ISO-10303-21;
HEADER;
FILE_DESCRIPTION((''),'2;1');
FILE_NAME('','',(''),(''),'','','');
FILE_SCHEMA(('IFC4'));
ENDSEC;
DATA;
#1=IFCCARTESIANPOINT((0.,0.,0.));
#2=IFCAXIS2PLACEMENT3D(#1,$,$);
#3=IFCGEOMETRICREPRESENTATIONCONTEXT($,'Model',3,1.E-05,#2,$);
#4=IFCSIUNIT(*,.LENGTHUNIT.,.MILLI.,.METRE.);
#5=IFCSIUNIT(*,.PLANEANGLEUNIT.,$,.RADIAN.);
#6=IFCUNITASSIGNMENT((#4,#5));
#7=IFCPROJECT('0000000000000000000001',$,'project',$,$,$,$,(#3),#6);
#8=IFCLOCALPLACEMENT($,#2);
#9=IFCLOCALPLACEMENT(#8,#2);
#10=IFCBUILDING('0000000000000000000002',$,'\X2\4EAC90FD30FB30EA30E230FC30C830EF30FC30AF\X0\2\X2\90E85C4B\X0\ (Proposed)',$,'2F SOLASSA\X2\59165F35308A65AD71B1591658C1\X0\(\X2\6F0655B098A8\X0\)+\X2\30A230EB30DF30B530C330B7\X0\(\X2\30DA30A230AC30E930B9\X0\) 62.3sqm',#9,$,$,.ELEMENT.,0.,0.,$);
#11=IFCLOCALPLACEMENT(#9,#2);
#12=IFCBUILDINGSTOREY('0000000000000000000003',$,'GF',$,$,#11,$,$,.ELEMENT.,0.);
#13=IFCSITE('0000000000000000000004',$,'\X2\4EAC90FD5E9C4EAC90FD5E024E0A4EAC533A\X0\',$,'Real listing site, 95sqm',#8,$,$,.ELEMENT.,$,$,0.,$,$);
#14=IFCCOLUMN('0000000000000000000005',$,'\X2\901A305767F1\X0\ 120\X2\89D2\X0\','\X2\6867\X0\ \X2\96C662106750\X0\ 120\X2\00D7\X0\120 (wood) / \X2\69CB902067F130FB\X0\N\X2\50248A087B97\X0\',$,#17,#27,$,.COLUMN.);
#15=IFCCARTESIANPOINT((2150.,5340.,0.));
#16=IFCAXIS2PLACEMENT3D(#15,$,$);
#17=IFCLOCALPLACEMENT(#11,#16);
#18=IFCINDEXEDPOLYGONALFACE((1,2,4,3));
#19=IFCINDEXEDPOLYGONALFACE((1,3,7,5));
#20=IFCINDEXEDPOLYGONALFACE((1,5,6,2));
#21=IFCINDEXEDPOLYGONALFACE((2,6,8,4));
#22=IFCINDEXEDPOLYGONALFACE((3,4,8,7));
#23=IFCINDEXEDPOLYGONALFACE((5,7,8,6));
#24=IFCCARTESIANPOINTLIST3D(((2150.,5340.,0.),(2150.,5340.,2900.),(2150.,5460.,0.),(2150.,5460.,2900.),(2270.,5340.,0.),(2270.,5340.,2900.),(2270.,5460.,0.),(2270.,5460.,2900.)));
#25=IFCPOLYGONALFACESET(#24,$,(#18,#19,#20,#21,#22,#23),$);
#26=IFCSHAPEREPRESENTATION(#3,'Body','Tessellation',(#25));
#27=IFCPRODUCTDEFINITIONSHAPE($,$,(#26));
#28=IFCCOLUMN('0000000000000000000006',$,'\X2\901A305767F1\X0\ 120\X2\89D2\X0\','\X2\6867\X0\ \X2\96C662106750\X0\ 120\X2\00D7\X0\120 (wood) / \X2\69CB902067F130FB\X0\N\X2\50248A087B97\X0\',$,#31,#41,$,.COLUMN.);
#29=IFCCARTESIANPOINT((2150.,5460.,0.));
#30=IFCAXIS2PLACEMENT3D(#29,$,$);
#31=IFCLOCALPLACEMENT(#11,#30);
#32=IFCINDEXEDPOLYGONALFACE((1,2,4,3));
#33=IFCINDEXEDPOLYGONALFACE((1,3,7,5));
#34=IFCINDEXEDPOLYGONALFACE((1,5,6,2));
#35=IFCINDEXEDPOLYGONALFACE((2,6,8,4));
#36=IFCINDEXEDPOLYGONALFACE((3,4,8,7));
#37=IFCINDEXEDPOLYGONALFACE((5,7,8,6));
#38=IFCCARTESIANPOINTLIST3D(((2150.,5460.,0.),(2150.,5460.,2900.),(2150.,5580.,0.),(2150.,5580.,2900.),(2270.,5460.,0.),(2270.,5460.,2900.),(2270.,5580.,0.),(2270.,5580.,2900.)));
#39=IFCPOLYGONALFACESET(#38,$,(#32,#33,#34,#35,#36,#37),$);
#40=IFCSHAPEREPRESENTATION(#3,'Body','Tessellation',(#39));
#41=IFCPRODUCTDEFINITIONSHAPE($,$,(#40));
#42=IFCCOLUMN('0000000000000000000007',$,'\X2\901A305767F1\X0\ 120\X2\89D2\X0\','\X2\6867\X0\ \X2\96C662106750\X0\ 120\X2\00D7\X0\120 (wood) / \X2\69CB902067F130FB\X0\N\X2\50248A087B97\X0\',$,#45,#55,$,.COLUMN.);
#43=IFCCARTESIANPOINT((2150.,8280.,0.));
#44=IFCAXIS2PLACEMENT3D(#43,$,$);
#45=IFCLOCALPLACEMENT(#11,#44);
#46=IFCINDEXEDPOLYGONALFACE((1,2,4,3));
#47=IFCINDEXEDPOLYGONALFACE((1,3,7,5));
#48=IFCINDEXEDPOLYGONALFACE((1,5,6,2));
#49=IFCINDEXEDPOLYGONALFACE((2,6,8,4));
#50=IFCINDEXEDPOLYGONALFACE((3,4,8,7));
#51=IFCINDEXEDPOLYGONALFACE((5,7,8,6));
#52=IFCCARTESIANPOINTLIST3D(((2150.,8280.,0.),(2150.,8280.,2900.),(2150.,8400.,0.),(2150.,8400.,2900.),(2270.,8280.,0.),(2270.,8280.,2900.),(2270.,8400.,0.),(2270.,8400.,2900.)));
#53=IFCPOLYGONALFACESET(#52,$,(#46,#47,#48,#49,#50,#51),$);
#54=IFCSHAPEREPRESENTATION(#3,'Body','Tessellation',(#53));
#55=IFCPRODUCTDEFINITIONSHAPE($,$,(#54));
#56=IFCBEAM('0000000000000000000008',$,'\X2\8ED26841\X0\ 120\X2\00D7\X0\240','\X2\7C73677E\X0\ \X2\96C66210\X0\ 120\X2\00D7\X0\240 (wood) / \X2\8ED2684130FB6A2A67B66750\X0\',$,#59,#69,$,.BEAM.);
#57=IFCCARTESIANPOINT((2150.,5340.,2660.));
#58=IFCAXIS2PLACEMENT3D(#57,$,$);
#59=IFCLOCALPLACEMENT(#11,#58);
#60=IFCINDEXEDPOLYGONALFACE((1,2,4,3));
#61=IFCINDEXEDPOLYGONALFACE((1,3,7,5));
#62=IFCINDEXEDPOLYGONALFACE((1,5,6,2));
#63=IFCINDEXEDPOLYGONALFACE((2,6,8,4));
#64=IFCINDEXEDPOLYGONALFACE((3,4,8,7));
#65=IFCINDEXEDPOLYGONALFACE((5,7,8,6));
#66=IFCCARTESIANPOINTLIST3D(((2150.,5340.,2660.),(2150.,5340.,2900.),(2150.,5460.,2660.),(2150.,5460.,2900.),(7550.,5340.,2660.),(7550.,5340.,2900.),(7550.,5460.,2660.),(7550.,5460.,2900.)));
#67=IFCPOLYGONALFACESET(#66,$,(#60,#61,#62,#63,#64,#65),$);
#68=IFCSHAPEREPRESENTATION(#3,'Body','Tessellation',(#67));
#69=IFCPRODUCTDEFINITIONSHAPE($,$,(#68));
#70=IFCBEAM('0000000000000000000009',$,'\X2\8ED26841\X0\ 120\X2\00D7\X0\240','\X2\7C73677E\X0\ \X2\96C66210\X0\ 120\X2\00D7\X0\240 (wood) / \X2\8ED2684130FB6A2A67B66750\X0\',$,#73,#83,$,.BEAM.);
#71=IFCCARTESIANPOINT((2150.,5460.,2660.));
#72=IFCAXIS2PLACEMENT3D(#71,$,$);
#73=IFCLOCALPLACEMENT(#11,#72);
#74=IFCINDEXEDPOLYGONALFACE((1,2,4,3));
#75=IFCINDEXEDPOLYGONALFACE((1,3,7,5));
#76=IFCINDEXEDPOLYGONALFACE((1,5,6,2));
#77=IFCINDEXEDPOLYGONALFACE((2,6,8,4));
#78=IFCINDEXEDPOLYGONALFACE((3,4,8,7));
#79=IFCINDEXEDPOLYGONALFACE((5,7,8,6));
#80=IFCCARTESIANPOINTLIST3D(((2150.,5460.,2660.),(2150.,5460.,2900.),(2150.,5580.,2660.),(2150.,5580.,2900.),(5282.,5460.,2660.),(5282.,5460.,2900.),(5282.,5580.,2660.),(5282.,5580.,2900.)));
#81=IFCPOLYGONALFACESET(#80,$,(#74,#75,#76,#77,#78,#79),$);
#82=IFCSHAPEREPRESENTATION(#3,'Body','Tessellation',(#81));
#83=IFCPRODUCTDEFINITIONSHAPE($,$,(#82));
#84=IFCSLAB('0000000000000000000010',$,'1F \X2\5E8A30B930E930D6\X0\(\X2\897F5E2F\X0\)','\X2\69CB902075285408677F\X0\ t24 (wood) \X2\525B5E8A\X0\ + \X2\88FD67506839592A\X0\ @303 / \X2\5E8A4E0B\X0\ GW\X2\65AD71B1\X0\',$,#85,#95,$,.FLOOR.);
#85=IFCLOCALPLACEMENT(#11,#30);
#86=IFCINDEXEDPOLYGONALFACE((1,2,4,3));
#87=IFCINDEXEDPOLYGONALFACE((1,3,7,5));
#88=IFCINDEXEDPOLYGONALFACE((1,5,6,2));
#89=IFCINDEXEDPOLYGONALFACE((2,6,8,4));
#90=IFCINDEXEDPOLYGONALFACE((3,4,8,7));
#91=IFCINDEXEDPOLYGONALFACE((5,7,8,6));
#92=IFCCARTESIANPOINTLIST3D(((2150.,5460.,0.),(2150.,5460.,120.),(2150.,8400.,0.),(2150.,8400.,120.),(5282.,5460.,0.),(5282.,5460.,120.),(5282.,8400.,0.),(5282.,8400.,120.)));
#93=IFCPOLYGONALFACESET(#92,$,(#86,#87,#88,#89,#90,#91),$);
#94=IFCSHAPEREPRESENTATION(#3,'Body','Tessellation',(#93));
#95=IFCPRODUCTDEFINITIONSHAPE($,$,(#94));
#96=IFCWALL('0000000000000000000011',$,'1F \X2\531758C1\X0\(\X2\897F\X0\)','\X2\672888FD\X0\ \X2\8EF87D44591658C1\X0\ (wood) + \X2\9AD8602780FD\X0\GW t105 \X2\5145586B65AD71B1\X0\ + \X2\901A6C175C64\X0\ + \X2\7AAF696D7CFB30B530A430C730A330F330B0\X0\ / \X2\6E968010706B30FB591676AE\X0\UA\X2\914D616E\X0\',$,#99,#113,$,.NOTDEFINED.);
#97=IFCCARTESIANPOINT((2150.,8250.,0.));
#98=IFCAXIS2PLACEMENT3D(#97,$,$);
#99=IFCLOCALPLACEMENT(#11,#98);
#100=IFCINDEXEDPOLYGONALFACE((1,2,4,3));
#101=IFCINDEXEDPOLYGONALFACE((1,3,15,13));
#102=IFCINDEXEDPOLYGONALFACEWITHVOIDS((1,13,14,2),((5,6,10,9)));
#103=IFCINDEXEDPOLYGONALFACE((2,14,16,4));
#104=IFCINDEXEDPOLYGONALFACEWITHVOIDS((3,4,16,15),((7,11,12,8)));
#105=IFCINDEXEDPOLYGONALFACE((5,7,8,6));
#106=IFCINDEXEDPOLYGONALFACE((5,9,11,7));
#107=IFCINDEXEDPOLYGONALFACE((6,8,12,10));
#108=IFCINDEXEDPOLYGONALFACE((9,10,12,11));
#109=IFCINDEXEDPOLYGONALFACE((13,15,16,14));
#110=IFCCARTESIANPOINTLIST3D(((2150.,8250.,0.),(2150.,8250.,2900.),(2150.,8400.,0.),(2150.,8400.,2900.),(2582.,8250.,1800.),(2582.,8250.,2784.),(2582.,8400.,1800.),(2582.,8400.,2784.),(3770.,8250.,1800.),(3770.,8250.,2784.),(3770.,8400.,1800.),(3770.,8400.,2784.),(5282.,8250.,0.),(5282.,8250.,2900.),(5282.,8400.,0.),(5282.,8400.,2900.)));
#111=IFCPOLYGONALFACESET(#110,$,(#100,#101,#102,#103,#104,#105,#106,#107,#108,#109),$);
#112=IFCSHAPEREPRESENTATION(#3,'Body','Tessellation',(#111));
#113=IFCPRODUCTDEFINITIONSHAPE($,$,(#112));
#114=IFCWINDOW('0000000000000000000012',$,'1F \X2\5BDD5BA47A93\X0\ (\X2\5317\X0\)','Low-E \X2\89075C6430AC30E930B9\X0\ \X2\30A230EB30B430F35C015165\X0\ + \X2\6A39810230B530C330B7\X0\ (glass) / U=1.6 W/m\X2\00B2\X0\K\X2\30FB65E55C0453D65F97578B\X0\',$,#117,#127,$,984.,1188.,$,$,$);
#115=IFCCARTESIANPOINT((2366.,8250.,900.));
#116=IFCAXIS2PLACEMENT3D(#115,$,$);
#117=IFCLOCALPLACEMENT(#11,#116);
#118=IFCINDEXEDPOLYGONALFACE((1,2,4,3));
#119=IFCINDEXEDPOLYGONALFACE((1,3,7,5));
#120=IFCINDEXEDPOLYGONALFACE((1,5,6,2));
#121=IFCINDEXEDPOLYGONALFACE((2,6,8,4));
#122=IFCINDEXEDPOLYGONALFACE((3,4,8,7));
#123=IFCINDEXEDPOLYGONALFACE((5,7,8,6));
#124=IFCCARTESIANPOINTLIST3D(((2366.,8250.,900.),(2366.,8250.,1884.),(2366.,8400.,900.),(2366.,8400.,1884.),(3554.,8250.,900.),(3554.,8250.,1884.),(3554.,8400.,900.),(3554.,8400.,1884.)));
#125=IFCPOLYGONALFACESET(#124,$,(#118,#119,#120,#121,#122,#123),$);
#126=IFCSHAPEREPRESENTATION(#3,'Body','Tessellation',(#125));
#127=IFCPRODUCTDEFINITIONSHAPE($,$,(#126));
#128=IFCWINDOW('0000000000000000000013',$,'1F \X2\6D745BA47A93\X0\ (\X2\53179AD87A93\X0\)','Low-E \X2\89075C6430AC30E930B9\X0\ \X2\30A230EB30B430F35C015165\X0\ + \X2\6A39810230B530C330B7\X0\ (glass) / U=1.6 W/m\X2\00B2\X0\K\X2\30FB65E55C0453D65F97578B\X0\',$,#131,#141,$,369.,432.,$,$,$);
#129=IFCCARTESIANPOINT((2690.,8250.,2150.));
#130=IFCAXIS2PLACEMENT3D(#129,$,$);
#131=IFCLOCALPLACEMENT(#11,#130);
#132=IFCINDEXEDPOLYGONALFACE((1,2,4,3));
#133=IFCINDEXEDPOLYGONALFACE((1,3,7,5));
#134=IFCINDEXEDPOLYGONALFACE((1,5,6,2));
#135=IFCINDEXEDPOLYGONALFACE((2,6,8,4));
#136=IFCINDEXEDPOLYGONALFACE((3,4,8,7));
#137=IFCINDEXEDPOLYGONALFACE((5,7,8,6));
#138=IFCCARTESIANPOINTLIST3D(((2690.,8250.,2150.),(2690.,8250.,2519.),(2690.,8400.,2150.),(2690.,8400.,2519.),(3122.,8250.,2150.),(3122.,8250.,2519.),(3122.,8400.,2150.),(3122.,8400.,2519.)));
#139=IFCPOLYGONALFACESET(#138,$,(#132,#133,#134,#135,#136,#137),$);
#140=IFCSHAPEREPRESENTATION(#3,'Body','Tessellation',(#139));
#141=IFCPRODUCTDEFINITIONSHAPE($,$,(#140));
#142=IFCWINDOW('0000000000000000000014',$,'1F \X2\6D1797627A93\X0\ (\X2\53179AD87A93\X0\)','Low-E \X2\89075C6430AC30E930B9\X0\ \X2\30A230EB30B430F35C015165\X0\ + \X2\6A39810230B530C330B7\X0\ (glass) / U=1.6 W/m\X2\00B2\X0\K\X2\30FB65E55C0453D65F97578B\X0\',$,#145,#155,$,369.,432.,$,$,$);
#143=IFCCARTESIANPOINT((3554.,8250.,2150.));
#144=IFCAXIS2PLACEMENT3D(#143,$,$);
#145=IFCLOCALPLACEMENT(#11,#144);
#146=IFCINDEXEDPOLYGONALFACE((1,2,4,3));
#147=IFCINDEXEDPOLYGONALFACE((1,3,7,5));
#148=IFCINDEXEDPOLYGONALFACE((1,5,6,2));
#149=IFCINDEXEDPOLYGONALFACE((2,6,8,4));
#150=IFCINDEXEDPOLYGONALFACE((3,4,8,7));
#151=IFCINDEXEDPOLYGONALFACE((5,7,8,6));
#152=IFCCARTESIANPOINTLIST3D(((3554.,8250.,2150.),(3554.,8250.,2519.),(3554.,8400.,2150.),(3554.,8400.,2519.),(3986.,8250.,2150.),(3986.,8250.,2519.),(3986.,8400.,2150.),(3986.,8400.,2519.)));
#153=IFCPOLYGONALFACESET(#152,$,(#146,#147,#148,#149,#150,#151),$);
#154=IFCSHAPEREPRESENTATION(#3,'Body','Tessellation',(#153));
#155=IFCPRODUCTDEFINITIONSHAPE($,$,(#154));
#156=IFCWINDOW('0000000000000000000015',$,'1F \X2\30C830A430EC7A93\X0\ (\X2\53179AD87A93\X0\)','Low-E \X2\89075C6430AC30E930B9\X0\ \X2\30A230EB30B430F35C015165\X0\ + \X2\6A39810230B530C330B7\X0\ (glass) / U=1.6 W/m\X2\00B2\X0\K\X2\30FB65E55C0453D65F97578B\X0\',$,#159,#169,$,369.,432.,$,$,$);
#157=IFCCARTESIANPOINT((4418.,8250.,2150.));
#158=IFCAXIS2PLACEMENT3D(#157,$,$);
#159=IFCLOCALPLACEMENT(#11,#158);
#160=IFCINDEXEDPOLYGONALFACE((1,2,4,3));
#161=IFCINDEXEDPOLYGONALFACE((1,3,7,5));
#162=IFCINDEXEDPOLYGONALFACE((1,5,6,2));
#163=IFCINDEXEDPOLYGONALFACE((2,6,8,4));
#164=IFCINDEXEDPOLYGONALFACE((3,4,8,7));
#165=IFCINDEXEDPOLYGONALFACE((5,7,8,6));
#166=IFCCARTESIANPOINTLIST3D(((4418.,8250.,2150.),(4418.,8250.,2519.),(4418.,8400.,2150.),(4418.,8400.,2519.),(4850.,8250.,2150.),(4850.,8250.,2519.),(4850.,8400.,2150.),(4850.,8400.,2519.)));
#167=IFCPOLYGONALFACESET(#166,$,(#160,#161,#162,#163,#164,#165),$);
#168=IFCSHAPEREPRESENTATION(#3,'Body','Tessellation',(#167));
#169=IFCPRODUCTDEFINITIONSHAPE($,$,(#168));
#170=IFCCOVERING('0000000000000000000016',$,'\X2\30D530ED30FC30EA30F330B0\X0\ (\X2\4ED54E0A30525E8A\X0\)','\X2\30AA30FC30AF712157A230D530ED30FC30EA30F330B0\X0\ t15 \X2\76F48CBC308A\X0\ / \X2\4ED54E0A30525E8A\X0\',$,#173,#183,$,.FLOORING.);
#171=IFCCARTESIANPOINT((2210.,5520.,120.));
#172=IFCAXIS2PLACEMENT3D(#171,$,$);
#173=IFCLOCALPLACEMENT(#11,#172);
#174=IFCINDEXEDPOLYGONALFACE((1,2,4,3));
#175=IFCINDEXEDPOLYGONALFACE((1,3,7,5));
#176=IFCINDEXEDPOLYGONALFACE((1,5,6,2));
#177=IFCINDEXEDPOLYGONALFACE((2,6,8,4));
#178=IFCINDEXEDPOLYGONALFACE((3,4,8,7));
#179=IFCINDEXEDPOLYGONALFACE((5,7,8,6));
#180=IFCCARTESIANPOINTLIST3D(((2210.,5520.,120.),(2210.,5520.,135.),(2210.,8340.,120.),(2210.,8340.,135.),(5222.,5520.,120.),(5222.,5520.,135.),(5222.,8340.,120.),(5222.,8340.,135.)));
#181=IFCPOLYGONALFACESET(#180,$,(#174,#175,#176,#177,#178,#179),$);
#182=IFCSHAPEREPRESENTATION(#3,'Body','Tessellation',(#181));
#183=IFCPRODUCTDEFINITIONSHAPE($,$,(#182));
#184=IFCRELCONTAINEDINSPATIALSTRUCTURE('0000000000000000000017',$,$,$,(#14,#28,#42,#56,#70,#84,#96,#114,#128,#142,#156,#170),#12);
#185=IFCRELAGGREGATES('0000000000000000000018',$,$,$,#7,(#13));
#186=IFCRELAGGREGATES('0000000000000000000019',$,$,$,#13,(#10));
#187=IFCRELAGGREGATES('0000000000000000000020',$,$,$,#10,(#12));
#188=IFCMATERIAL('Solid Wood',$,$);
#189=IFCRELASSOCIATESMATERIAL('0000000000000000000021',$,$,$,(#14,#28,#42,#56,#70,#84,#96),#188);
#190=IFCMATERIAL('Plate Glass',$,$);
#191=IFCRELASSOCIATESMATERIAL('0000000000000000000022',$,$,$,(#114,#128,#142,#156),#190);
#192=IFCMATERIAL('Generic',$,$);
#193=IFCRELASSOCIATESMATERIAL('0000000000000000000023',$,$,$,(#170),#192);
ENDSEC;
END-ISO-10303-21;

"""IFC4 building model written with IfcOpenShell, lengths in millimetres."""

from ifc_helpers import new_model, si_unit, frame, frame_2d, origin, place, context, project, spatial, rectangle, extrude, material, element, fill, save


model = new_model("IFC4")

# Units and contexts
model_context = context("Model", 3, precision=1e-05, world=origin())
ifc_project = project(units=[si_unit("LENGTHUNIT", "METRE", prefix="MILLI"), si_unit("PLANEANGLEUNIT", "RADIAN")], contexts=[model_context])

# Site, building, storey
site_placement = place(None, origin())
site = spatial("IfcSite", under=ifc_project, at=site_placement, Name="京都府京都市上京区", ObjectType="Real listing site, 95sqm", CompositionType="ELEMENT", RefElevation=0.0)
building_placement = place(site_placement, origin())
building = spatial("IfcBuilding", under=site, at=building_placement, Name="京都・リモートワーク2部屋 (Proposed)", ObjectType="2F SOLASSA外張り断熱外壁(漆喰風)+アルミサッシ(ペアガラス) 62.3sqm", CompositionType="ELEMENT", ElevationOfRefHeight=0.0, ElevationOfTerrain=0.0)
storey_placement = place(building_placement, origin())
storey = spatial("IfcBuildingStorey", under=building, at=storey_placement, Name="GF", CompositionType="ELEMENT", Elevation=0.0)

# Columns
ifc_material_1 = material(Name="Solid Wood")
column_1_placement = place(storey_placement, frame((2150.0, 5340.0, 0.0)))
element("IfcColumn", 1, at=column_1_placement, inside=storey, material=ifc_material_1, Name="通し柱 120角", Description="桧 集成材 120×120 (wood) / 構造柱・N値計算", PredefinedType="COLUMN", context=model_context, shape_type="SweptSolid", body=[
    extrude(rectangle(XDim=120.0, YDim=120.0, at=frame_2d((60.0, 60.0))), frame((2150.0, 5340.0, 0.0)), (0.0, 0.0, 1.0), 2900.0),
])
column_2_placement = place(storey_placement, frame((2150.0, 5460.0, 0.0)))
element("IfcColumn", 2, at=column_2_placement, inside=storey, material=ifc_material_1, Name="通し柱 120角", Description="桧 集成材 120×120 (wood) / 構造柱・N値計算", PredefinedType="COLUMN", context=model_context, shape_type="SweptSolid", body=[
    extrude(rectangle(XDim=120.0, YDim=120.0, at=frame_2d((60.0, 60.0))), frame((2150.0, 5460.0, 0.0)), (0.0, 0.0, 1.0), 2900.0),
])
column_3_placement = place(storey_placement, frame((2150.0, 8280.0, 0.0)))
element("IfcColumn", 3, at=column_3_placement, inside=storey, material=ifc_material_1, Name="通し柱 120角", Description="桧 集成材 120×120 (wood) / 構造柱・N値計算", PredefinedType="COLUMN", context=model_context, shape_type="SweptSolid", body=[
    extrude(rectangle(XDim=120.0, YDim=120.0, at=frame_2d((60.0, 60.0))), frame((2150.0, 8280.0, 0.0)), (0.0, 0.0, 1.0), 2900.0),
])

# Beams
beam_1_placement = place(storey_placement, frame((2150.0, 5340.0, 2660.0)))
element("IfcBeam", 4, at=beam_1_placement, inside=storey, material=ifc_material_1, Name="軒桁 120×240", Description="米松 集成 120×240 (wood) / 軒桁・横架材", PredefinedType="BEAM", context=model_context, shape_type="SweptSolid", body=[
    extrude(rectangle(XDim=5400.0, YDim=120.0, at=frame_2d((2700.0, 60.0))), frame((2150.0, 5340.0, 2660.0)), (0.0, 0.0, 1.0), 240.0),
])
beam_2_placement = place(storey_placement, frame((2150.0, 5460.0, 2660.0)))
element("IfcBeam", 5, at=beam_2_placement, inside=storey, material=ifc_material_1, Name="軒桁 120×240", Description="米松 集成 120×240 (wood) / 軒桁・横架材", PredefinedType="BEAM", context=model_context, shape_type="SweptSolid", body=[
    extrude(rectangle(XDim=3132.0, YDim=120.0, at=frame_2d((1566.0, 60.0))), frame((2150.0, 5460.0, 2660.0)), (0.0, 0.0, 1.0), 240.0),
])

# Slab
slab_placement = place(storey_placement, frame((2150.0, 5460.0, 0.0)))
element("IfcSlab", 6, at=slab_placement, inside=storey, material=ifc_material_1, Name="1F 床スラブ(西帯)", Description="構造用合板 t24 (wood) 剛床 + 製材根太 @303 / 床下 GW断熱", PredefinedType="FLOOR", context=model_context, shape_type="SweptSolid", body=[
    extrude(rectangle(XDim=3132.0, YDim=2940.0, at=frame_2d((1566.0, 1470.0))), frame((2150.0, 5460.0, 0.0)), (0.0, 0.0, 1.0), 120.0),
])

# Wall, openings, windows
wall_1_placement = place(storey_placement, frame((2150.0, 8250.0, 0.0)))
wall_1 = element("IfcWall", 7, at=wall_1_placement, inside=storey, material=ifc_material_1, Name="1F 北壁(西)", Description="木製 軸組外壁 (wood) + 高性能GW t105 充填断熱 + 通気層 + 窯業系サイディング / 準耐火・外皮UA配慮", PredefinedType="NOTDEFINED", context=model_context, shape_type="SweptSolid", body=[
    extrude(rectangle(XDim=3132.0, YDim=150.0, at=frame_2d((1566.0, 75.0))), frame((2150.0, 8250.0, 0.0)), (0.0, 0.0, 1.0), 2900.0),
])
opening_1_placement = place(storey_placement, frame((2366.0, 8250.0, 900.0)))
opening_1 = element("IfcOpeningElement", 8, at=opening_1_placement, cuts=wall_1, PredefinedType="NOTDEFINED", context=model_context, shape_type="SweptSolid", body=[
    extrude(rectangle(XDim=1188.0, YDim=150.0, at=frame_2d((594.0, 75.0))), frame((2366.0, 8250.0, 900.0)), (0.0, 0.0, 1.0), 984.0),
])
opening_2_placement = place(storey_placement, frame((2690.0, 8250.0, 2150.0)))
opening_2 = element("IfcOpeningElement", 9, at=opening_2_placement, cuts=wall_1, PredefinedType="NOTDEFINED", context=model_context, shape_type="SweptSolid", body=[
    extrude(rectangle(XDim=432.0, YDim=150.0, at=frame_2d((216.0, 75.0))), frame((2690.0, 8250.0, 2150.0)), (0.0, 0.0, 1.0), 369.0),
])
opening_3_placement = place(storey_placement, frame((3554.0, 8250.0, 2150.0)))
opening_3 = element("IfcOpeningElement", 10, at=opening_3_placement, cuts=wall_1, PredefinedType="NOTDEFINED", context=model_context, shape_type="SweptSolid", body=[
    extrude(rectangle(XDim=432.0, YDim=150.0, at=frame_2d((216.0, 75.0))), frame((3554.0, 8250.0, 2150.0)), (0.0, 0.0, 1.0), 369.0),
])
opening_4_placement = place(storey_placement, frame((4418.0, 8250.0, 2150.0)))
opening_4 = element("IfcOpeningElement", 11, at=opening_4_placement, cuts=wall_1, PredefinedType="NOTDEFINED", context=model_context, shape_type="SweptSolid", body=[
    extrude(rectangle(XDim=432.0, YDim=150.0, at=frame_2d((216.0, 75.0))), frame((4418.0, 8250.0, 2150.0)), (0.0, 0.0, 1.0), 369.0),
])
ifc_material_2 = material(Name="Plate Glass")
window_1_placement = place(storey_placement, frame((2366.0, 8250.0, 900.0)))
window_1 = element("IfcWindow", 12, at=window_1_placement, inside=storey, material=ifc_material_2, Name="1F 寝室窓 (北)", Description="Low-E 複層ガラス アルゴン封入 + 樹脂サッシ (glass) / U=1.6 W/m²K・日射取得型", OverallHeight=984.0, OverallWidth=1188.0, context=model_context, shape_type="SweptSolid", body=[
    extrude(rectangle(XDim=1188.0, YDim=150.0, at=frame_2d((594.0, 75.0))), frame((2366.0, 8250.0, 900.0)), (0.0, 0.0, 1.0), 984.0),
])
fill(opening_1, window_1)
window_2_placement = place(storey_placement, frame((2690.0, 8250.0, 2150.0)))
window_2 = element("IfcWindow", 13, at=window_2_placement, inside=storey, material=ifc_material_2, Name="1F 浴室窓 (北高窓)", Description="Low-E 複層ガラス アルゴン封入 + 樹脂サッシ (glass) / U=1.6 W/m²K・日射取得型", OverallHeight=369.0, OverallWidth=432.0, context=model_context, shape_type="SweptSolid", body=[
    extrude(rectangle(XDim=432.0, YDim=150.0, at=frame_2d((216.0, 75.0))), frame((2690.0, 8250.0, 2150.0)), (0.0, 0.0, 1.0), 369.0),
])
fill(opening_2, window_2)
window_3_placement = place(storey_placement, frame((3554.0, 8250.0, 2150.0)))
window_3 = element("IfcWindow", 14, at=window_3_placement, inside=storey, material=ifc_material_2, Name="1F 洗面窓 (北高窓)", Description="Low-E 複層ガラス アルゴン封入 + 樹脂サッシ (glass) / U=1.6 W/m²K・日射取得型", OverallHeight=369.0, OverallWidth=432.0, context=model_context, shape_type="SweptSolid", body=[
    extrude(rectangle(XDim=432.0, YDim=150.0, at=frame_2d((216.0, 75.0))), frame((3554.0, 8250.0, 2150.0)), (0.0, 0.0, 1.0), 369.0),
])
fill(opening_3, window_3)
window_4_placement = place(storey_placement, frame((4418.0, 8250.0, 2150.0)))
window_4 = element("IfcWindow", 15, at=window_4_placement, inside=storey, material=ifc_material_2, Name="1F トイレ窓 (北高窓)", Description="Low-E 複層ガラス アルゴン封入 + 樹脂サッシ (glass) / U=1.6 W/m²K・日射取得型", OverallHeight=369.0, OverallWidth=432.0, context=model_context, shape_type="SweptSolid", body=[
    extrude(rectangle(XDim=432.0, YDim=150.0, at=frame_2d((216.0, 75.0))), frame((4418.0, 8250.0, 2150.0)), (0.0, 0.0, 1.0), 369.0),
])
fill(opening_4, window_4)

# Covering
ifc_material_3 = material(Name="Generic")
covering_placement = place(storey_placement, frame((2210.0, 5520.0, 120.0)))
element("IfcCovering", 16, at=covering_placement, inside=storey, material=ifc_material_3, Name="フローリング (仕上げ床)", Description="オーク無垢フローリング t15 直貼り / 仕上げ床", PredefinedType="FLOORING", context=model_context, shape_type="SweptSolid", body=[
    extrude(rectangle(XDim=3012.0, YDim=2820.0, at=frame_2d((1506.0, 1410.0))), frame((2210.0, 5520.0, 120.0)), (0.0, 0.0, 1.0), 15.0),
])

save(model, "model.ifc")
